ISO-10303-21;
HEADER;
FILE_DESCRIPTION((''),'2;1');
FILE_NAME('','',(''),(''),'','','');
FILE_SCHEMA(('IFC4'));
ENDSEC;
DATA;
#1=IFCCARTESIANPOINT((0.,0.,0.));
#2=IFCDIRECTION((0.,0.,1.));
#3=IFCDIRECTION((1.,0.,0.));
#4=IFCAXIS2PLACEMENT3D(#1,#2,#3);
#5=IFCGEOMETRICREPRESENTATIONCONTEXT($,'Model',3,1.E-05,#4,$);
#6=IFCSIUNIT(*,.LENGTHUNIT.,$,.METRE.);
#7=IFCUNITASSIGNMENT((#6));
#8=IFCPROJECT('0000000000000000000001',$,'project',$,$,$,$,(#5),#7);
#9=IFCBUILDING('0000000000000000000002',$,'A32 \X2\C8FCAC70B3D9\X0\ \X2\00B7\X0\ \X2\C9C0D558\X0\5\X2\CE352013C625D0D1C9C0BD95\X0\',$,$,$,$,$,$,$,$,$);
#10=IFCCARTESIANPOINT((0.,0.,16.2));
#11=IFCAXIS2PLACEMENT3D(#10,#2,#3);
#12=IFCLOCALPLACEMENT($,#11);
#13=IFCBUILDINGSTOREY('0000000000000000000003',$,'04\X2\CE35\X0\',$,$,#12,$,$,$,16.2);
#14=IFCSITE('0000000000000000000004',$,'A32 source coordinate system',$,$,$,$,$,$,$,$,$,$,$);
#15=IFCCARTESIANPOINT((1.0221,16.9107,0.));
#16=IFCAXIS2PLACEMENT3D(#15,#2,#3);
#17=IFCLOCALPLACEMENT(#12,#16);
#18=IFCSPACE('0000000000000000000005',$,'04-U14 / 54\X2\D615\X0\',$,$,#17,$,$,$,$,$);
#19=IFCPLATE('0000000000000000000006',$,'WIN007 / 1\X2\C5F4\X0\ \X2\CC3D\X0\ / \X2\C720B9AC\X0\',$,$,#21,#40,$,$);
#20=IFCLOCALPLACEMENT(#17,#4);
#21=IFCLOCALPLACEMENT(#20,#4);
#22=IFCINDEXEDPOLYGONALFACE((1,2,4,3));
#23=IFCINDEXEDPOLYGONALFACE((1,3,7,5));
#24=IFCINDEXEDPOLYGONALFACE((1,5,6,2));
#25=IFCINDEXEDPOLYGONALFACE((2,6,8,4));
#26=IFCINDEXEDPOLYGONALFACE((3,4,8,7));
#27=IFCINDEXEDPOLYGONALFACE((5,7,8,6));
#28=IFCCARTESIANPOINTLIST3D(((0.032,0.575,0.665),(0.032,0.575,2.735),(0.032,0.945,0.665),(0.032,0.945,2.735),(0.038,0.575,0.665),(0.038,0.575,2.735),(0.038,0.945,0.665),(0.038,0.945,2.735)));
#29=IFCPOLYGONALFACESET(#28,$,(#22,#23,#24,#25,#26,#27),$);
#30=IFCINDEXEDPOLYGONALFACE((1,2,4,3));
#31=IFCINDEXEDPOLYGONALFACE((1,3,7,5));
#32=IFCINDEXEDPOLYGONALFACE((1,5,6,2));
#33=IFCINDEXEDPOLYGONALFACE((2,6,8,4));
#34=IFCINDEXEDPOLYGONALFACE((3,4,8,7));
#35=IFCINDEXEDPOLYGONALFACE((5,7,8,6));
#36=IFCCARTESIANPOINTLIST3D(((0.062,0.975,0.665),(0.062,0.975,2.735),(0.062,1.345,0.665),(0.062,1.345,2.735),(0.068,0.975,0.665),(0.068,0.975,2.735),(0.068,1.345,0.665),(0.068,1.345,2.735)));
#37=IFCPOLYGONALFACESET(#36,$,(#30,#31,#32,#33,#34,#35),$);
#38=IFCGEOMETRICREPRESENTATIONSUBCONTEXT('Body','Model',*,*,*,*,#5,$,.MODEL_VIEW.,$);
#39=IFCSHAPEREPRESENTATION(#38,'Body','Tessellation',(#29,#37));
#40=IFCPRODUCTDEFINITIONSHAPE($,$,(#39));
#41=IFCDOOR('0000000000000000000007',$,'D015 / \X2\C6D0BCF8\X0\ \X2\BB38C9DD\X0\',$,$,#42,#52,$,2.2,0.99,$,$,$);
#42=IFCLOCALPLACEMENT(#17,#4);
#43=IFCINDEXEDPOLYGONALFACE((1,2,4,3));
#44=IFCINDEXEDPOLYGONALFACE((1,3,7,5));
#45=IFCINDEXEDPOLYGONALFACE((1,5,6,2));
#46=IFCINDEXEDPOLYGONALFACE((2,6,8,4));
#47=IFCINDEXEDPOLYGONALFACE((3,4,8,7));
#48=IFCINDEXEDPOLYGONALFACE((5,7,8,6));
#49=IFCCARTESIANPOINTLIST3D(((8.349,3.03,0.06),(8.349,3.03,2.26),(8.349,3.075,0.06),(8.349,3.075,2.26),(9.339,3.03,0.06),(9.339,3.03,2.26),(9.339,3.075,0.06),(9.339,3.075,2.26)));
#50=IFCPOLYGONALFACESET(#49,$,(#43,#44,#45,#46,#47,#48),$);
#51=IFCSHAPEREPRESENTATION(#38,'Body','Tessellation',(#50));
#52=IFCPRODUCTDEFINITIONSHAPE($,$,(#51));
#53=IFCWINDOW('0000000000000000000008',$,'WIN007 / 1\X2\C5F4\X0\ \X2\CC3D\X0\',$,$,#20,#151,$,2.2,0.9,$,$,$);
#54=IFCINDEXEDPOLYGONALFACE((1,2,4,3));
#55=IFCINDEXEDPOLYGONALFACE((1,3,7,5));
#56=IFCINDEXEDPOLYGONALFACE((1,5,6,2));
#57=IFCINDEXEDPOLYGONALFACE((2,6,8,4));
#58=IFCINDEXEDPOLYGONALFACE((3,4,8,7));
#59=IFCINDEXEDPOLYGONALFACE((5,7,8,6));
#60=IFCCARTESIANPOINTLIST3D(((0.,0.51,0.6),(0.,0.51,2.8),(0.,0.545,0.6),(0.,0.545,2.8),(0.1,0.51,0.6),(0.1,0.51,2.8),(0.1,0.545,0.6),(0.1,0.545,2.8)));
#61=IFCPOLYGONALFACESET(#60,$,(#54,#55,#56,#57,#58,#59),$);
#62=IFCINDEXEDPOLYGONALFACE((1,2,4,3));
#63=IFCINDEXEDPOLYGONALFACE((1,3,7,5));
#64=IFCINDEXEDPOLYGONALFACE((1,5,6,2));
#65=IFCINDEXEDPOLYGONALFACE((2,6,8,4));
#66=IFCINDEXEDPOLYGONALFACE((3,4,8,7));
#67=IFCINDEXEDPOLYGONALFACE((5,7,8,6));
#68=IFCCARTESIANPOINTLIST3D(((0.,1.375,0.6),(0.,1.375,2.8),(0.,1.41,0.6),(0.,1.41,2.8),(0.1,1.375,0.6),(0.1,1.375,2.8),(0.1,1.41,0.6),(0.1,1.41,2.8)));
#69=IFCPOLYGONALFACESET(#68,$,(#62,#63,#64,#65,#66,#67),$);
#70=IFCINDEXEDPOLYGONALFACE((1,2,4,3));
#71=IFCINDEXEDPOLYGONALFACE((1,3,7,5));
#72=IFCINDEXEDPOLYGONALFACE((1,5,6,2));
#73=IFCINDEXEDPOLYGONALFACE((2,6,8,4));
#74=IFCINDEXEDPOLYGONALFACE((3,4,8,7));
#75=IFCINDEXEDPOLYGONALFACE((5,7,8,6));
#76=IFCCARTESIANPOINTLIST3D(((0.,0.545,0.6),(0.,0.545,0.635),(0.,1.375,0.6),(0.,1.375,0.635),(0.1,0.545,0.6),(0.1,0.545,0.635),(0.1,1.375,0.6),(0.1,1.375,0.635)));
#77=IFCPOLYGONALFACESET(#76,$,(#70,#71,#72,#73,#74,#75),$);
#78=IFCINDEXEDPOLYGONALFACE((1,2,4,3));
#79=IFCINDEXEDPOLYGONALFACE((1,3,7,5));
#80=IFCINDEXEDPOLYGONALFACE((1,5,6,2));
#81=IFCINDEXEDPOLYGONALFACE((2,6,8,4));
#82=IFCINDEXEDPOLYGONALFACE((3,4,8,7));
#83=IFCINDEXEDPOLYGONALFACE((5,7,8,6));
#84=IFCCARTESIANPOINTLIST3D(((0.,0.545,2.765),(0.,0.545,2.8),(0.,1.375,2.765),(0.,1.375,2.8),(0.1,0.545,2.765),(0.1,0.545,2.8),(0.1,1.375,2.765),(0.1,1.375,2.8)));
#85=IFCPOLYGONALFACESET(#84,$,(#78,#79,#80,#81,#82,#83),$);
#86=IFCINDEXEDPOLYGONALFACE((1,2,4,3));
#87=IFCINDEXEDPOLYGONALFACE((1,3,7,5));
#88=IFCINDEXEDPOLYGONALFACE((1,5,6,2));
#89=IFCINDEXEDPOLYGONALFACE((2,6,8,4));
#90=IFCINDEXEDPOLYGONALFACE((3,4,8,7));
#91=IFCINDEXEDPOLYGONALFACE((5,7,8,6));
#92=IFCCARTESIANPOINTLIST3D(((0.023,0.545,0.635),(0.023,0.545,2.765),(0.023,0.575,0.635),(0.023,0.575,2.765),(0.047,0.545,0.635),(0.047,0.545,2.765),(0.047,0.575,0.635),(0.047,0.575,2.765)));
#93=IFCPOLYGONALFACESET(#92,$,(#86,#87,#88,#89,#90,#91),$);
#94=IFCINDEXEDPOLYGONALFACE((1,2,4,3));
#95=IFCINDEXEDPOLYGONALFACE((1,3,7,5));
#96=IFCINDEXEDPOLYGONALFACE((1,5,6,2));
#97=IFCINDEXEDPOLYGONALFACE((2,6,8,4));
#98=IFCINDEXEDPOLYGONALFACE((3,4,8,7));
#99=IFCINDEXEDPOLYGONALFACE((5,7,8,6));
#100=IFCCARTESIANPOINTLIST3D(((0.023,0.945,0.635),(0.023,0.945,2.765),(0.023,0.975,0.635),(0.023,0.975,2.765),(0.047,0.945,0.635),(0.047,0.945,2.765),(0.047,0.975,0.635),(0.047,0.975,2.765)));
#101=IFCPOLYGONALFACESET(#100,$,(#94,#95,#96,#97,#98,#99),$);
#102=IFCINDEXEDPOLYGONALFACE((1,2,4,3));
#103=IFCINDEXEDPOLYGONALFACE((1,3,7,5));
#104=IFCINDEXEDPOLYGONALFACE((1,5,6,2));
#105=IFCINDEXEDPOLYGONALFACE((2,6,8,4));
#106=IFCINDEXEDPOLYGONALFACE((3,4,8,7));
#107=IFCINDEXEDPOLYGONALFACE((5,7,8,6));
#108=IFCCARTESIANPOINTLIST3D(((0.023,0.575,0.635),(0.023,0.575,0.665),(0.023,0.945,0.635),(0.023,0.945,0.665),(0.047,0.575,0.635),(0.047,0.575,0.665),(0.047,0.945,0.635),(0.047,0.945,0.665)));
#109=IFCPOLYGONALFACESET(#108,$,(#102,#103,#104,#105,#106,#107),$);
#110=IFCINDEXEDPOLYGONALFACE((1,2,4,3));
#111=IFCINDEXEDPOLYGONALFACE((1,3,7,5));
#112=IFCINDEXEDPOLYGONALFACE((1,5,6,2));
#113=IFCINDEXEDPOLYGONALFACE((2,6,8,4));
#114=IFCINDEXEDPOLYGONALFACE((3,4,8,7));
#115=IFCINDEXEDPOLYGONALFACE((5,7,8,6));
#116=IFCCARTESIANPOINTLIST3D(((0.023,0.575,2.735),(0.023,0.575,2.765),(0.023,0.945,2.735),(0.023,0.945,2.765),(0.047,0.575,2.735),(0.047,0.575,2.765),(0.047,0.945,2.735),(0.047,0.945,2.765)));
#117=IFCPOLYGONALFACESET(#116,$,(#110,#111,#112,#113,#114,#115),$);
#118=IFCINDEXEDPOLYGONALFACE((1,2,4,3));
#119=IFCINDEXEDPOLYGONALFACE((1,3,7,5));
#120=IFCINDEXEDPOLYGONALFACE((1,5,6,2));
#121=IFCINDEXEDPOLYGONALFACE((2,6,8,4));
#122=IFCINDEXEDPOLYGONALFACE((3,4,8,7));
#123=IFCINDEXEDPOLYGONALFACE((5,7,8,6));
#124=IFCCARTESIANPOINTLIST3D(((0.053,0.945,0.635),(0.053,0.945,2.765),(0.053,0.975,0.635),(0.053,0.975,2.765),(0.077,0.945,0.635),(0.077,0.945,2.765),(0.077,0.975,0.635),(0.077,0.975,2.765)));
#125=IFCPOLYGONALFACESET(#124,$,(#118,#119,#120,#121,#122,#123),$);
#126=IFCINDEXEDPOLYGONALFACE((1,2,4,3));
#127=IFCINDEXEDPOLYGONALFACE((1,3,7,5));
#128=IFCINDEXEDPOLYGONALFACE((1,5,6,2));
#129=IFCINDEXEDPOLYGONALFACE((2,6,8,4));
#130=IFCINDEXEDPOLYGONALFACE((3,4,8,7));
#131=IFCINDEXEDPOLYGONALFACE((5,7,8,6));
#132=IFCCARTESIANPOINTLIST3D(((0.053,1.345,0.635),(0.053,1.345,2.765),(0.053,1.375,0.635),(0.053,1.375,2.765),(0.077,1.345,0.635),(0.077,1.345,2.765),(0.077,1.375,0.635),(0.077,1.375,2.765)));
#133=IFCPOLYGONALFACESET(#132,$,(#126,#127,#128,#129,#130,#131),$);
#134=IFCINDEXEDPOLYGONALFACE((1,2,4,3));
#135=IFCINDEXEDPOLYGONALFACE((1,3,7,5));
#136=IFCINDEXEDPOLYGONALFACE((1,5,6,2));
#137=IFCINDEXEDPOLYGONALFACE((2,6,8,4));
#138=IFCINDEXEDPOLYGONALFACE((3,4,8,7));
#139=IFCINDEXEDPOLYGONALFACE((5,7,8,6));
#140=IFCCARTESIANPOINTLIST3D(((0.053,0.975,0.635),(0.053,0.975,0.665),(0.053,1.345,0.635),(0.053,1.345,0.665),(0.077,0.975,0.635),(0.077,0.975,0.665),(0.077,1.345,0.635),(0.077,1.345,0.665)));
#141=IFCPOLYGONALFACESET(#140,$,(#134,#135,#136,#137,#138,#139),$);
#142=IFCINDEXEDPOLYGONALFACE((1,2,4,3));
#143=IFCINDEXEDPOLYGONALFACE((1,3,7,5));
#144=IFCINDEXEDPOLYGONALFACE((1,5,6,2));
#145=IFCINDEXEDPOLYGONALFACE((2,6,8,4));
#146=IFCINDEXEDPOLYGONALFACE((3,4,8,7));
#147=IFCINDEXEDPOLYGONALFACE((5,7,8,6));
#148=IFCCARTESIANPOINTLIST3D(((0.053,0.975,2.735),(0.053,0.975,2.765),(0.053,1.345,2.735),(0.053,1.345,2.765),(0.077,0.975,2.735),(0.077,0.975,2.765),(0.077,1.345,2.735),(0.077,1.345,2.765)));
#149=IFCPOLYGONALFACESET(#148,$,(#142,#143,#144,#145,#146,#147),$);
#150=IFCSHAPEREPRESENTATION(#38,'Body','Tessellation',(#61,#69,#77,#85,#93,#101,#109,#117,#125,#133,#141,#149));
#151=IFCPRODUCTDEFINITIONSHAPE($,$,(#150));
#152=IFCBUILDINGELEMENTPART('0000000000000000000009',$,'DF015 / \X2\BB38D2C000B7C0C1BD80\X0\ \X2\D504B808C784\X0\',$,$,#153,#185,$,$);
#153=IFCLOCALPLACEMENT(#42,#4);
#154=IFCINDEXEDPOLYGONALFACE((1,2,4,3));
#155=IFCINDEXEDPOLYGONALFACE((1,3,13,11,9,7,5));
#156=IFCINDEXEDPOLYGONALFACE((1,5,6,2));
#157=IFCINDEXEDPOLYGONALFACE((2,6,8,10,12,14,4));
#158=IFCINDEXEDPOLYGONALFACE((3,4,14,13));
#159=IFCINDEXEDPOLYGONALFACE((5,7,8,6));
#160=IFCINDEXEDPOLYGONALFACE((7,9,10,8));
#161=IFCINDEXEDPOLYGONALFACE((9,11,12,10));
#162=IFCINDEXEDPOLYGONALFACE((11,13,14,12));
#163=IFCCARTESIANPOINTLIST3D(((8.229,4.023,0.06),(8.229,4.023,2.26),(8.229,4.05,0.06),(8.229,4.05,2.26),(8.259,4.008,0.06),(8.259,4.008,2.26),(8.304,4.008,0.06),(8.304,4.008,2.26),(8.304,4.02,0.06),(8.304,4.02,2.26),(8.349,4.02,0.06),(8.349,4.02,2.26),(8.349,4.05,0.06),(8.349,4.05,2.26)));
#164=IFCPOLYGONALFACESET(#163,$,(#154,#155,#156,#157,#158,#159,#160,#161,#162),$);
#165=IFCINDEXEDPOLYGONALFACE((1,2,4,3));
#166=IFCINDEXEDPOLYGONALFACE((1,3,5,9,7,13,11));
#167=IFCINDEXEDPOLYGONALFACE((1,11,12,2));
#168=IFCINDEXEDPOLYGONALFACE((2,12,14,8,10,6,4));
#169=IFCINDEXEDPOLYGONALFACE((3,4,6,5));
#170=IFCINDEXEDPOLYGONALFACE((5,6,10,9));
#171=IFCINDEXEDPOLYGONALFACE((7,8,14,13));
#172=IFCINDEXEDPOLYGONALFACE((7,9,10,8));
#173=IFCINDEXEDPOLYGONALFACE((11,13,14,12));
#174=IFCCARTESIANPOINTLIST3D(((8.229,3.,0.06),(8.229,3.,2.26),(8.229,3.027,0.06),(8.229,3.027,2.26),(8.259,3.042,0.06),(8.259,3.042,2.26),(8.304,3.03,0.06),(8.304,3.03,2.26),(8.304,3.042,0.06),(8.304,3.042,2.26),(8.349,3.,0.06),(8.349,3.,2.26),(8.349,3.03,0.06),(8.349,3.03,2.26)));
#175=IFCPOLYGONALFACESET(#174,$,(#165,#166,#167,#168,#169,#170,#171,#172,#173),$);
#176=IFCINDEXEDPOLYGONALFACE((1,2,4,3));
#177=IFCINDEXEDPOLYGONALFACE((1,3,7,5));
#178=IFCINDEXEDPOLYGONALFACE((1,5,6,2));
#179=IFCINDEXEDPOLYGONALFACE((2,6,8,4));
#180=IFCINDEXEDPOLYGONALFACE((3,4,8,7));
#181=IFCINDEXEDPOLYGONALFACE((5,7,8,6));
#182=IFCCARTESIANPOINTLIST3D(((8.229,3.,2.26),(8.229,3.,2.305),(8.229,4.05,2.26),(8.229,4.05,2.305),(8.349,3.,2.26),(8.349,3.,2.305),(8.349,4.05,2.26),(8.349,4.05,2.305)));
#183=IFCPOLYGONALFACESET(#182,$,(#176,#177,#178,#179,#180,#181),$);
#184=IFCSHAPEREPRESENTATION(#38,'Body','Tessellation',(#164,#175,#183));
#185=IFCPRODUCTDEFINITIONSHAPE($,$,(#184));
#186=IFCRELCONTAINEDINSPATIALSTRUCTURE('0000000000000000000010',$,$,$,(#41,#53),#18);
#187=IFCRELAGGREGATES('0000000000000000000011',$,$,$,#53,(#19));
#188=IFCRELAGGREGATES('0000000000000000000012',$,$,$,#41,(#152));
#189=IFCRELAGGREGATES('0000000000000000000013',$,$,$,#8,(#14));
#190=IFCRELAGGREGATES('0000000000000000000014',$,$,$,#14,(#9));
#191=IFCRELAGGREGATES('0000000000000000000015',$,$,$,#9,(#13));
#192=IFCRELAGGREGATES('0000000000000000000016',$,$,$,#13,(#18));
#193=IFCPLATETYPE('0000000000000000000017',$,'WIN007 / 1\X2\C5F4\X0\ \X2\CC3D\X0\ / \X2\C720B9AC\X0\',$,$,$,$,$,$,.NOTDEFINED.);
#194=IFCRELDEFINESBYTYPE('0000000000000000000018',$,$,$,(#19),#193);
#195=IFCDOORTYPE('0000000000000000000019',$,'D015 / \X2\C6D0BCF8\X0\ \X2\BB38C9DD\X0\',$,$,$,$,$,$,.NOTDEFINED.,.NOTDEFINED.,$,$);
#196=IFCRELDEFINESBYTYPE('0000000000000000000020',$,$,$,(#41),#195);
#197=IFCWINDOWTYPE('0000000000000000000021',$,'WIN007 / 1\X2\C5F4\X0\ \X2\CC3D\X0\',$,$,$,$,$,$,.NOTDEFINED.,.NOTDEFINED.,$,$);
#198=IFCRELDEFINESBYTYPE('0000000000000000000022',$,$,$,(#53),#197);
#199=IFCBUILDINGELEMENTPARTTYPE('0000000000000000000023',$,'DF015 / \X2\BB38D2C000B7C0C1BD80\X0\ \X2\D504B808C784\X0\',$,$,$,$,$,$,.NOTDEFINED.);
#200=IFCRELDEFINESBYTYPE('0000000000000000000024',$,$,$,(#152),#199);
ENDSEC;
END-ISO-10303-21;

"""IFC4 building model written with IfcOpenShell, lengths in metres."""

from ifc_helpers import new_model, si_unit, frame, origin, origin_with_axes, place, context, subcontext, project, spatial, polyline, outline, extrude, source, transform, mapped, type_object, type_shapes, element, aggregate, save


model = new_model("IFC4")

# Units and contexts
model_context = context("Model", 3, precision=1e-05, world=origin_with_axes())
body_context = subcontext(model_context, "Body", "Model", "MODEL_VIEW")
ifc_project = project(units=[si_unit("LENGTHUNIT", "METRE")], contexts=[model_context])

# Plate
plate_type_1 = type_object("IfcPlateType", Name="WIN007 / 1열 창 / 유리", PredefinedType="NOTDEFINED")
shared_shape_1 = source(origin(), body_context, "Body", "SweptSolid", [
    extrude(outline(polyline([(0.032, 0.575), (0.032, 0.945), (0.038, 0.945), (0.038, 0.575), (0.032, 0.575)])), frame((0.0, 0.0, 0.665)), (0.0, 0.0, 1.0), 2.07),
    extrude(outline(polyline([(0.062, 0.975), (0.062, 1.345), (0.068, 1.345), (0.068, 0.975), (0.062, 0.975)])), frame((0.0, 0.0, 0.665)), (0.0, 0.0, 1.0), 2.07),
])
type_shapes(plate_type_1, [shared_shape_1])
storey_placement = place(None, frame((0.0, 0.0, 16.2), z_axis=(0.0, 0.0, 1.0), x_axis=(1.0, 0.0, 0.0)))
space_1_placement = place(storey_placement, frame((1.0221, 16.9107, 0.0), z_axis=(0.0, 0.0, 1.0), x_axis=(1.0, 0.0, 0.0)))
window_1_placement = place(space_1_placement, origin_with_axes())
plate_1_placement = place(window_1_placement, origin_with_axes())
plate_1 = element("IfcPlate", 1, at=plate_1_placement, type_object=plate_type_1, Name="WIN007 / 1열 창 / 유리", context=body_context, shape_type="MappedRepresentation", body=[
    mapped(shared_shape_1, transform((0.0, 0.0, 0.0), scale=1.0)),
])

# Site, building, storey, space
site = spatial("IfcSite", under=ifc_project, Name="A32 source coordinate system")
building = spatial("IfcBuilding", under=site, Name="A32 주거동 · 지하5층–옥탑지붕")
storey = spatial("IfcBuildingStorey", under=building, at=storey_placement, Name="04층", Elevation=16.2)
space_1 = spatial("IfcSpace", under=storey, at=space_1_placement, Name="04-U14 / 54형")

# Door
door_type_1 = type_object("IfcDoorType", Name="D015 / 원본 문짝", OperationType="NOTDEFINED", PredefinedType="NOTDEFINED")
shared_shape_2 = source(origin(), body_context, "Body", "SweptSolid", [
    extrude(outline(polyline([(9.339, 3.075), (9.339, 3.03), (8.349, 3.03), (8.349, 3.075), (9.339, 3.075)])), frame((0.0, 0.0, 0.06)), (0.0, 0.0, 1.0), 2.2),
])
type_shapes(door_type_1, [shared_shape_2])
door_1_placement = place(space_1_placement, origin_with_axes())
door_1 = element("IfcDoor", 2, at=door_1_placement, inside=space_1, type_object=door_type_1, Name="D015 / 원본 문짝", OverallHeight=2.2, OverallWidth=0.99, context=body_context, shape_type="MappedRepresentation", body=[
    mapped(shared_shape_2, transform((0.0, 0.0, 0.0), scale=1.0)),
])

# Window
window_type_1 = type_object("IfcWindowType", Name="WIN007 / 1열 창", PartitioningType="NOTDEFINED", PredefinedType="NOTDEFINED")
shared_shape_3 = source(origin(), body_context, "Body", "SweptSolid", [
    extrude(outline(polyline([(0.0, 0.51), (0.0, 0.545), (0.1, 0.545), (0.1, 0.51), (0.0, 0.51)])), frame((0.0, 0.0, 0.6)), (0.0, 0.0, 1.0), 2.2),
    extrude(outline(polyline([(0.0, 1.375), (0.0, 1.41), (0.1, 1.41), (0.1, 1.375), (0.0, 1.375)])), frame((0.0, 0.0, 0.6)), (0.0, 0.0, 1.0), 2.2),
    extrude(outline(polyline([(0.0, 0.545), (0.0, 1.375), (0.1, 1.375), (0.1, 0.545), (0.0, 0.545)])), frame((0.0, 0.0, 0.6)), (0.0, 0.0, 1.0), 0.035),
    extrude(outline(polyline([(0.0, 0.545), (0.0, 1.375), (0.1, 1.375), (0.1, 0.545), (0.0, 0.545)])), frame((0.0, 0.0, 2.765)), (0.0, 0.0, 1.0), 0.035),
    extrude(outline(polyline([(0.023, 0.545), (0.023, 0.575), (0.047, 0.575), (0.047, 0.545), (0.023, 0.545)])), frame((0.0, 0.0, 0.635)), (0.0, 0.0, 1.0), 2.13),
    extrude(outline(polyline([(0.023, 0.945), (0.023, 0.975), (0.047, 0.975), (0.047, 0.945), (0.023, 0.945)])), frame((0.0, 0.0, 0.635)), (0.0, 0.0, 1.0), 2.13),
    extrude(outline(polyline([(0.023, 0.575), (0.023, 0.945), (0.047, 0.945), (0.047, 0.575), (0.023, 0.575)])), frame((0.0, 0.0, 0.635)), (0.0, 0.0, 1.0), 0.03),
    extrude(outline(polyline([(0.023, 0.575), (0.023, 0.945), (0.047, 0.945), (0.047, 0.575), (0.023, 0.575)])), frame((0.0, 0.0, 2.735)), (0.0, 0.0, 1.0), 0.03),
    extrude(outline(polyline([(0.053, 0.945), (0.053, 0.975), (0.077, 0.975), (0.077, 0.945), (0.053, 0.945)])), frame((0.0, 0.0, 0.635)), (0.0, 0.0, 1.0), 2.13),
    extrude(outline(polyline([(0.053, 1.345), (0.053, 1.375), (0.077, 1.375), (0.077, 1.345), (0.053, 1.345)])), frame((0.0, 0.0, 0.635)), (0.0, 0.0, 1.0), 2.13),
    extrude(outline(polyline([(0.053, 0.975), (0.053, 1.345), (0.077, 1.345), (0.077, 0.975), (0.053, 0.975)])), frame((0.0, 0.0, 0.635)), (0.0, 0.0, 1.0), 0.03),
    extrude(outline(polyline([(0.053, 0.975), (0.053, 1.345), (0.077, 1.345), (0.077, 0.975), (0.053, 0.975)])), frame((0.0, 0.0, 2.735)), (0.0, 0.0, 1.0), 0.03),
])
type_shapes(window_type_1, [shared_shape_3])
window_1 = element("IfcWindow", 3, at=window_1_placement, inside=space_1, type_object=window_type_1, Name="WIN007 / 1열 창", OverallHeight=2.2, OverallWidth=0.9, context=body_context, shape_type="MappedRepresentation", body=[
    mapped(shared_shape_3, transform((0.0, 0.0, 0.0), scale=1.0)),
])
aggregate(window_1, [plate_1])

# Building element part
building_element_part_type_1 = type_object("IfcBuildingElementPartType", Name="DF015 / 문틀·상부 프레임", PredefinedType="NOTDEFINED")
shared_shape_4 = source(origin(), body_context, "Body", "SweptSolid", [
    extrude(outline(polyline([(8.349, 4.02), (8.304, 4.02), (8.304, 4.008), (8.259, 4.008), (8.229, 4.023), (8.229, 4.05), (8.349, 4.05), (8.349, 4.02)])), frame((0.0, 0.0, 0.06)), (0.0, 0.0, 1.0), 2.2),
    extrude(outline(polyline([(8.229, 3.0), (8.229, 3.027), (8.259, 3.042), (8.304, 3.042), (8.304, 3.03), (8.349, 3.03), (8.349, 3.0), (8.229, 3.0)])), frame((0.0, 0.0, 0.06)), (0.0, 0.0, 1.0), 2.2),
    extrude(outline(polyline([(8.229, 3.0), (8.229, 4.05), (8.349, 4.05), (8.349, 3.0), (8.229, 3.0)])), frame((0.0, 0.0, 2.26)), (0.0, 0.0, 1.0), 0.045),
])
type_shapes(building_element_part_type_1, [shared_shape_4])
building_element_part_1_placement = place(door_1_placement, origin_with_axes())
building_element_part_1 = element("IfcBuildingElementPart", 4, at=building_element_part_1_placement, type_object=building_element_part_type_1, Name="DF015 / 문틀·상부 프레임", context=body_context, shape_type="MappedRepresentation", body=[
    mapped(shared_shape_4, transform((0.0, 0.0, 0.0), scale=1.0)),
])
aggregate(door_1, [building_element_part_1])

save(model, "model.ifc")
